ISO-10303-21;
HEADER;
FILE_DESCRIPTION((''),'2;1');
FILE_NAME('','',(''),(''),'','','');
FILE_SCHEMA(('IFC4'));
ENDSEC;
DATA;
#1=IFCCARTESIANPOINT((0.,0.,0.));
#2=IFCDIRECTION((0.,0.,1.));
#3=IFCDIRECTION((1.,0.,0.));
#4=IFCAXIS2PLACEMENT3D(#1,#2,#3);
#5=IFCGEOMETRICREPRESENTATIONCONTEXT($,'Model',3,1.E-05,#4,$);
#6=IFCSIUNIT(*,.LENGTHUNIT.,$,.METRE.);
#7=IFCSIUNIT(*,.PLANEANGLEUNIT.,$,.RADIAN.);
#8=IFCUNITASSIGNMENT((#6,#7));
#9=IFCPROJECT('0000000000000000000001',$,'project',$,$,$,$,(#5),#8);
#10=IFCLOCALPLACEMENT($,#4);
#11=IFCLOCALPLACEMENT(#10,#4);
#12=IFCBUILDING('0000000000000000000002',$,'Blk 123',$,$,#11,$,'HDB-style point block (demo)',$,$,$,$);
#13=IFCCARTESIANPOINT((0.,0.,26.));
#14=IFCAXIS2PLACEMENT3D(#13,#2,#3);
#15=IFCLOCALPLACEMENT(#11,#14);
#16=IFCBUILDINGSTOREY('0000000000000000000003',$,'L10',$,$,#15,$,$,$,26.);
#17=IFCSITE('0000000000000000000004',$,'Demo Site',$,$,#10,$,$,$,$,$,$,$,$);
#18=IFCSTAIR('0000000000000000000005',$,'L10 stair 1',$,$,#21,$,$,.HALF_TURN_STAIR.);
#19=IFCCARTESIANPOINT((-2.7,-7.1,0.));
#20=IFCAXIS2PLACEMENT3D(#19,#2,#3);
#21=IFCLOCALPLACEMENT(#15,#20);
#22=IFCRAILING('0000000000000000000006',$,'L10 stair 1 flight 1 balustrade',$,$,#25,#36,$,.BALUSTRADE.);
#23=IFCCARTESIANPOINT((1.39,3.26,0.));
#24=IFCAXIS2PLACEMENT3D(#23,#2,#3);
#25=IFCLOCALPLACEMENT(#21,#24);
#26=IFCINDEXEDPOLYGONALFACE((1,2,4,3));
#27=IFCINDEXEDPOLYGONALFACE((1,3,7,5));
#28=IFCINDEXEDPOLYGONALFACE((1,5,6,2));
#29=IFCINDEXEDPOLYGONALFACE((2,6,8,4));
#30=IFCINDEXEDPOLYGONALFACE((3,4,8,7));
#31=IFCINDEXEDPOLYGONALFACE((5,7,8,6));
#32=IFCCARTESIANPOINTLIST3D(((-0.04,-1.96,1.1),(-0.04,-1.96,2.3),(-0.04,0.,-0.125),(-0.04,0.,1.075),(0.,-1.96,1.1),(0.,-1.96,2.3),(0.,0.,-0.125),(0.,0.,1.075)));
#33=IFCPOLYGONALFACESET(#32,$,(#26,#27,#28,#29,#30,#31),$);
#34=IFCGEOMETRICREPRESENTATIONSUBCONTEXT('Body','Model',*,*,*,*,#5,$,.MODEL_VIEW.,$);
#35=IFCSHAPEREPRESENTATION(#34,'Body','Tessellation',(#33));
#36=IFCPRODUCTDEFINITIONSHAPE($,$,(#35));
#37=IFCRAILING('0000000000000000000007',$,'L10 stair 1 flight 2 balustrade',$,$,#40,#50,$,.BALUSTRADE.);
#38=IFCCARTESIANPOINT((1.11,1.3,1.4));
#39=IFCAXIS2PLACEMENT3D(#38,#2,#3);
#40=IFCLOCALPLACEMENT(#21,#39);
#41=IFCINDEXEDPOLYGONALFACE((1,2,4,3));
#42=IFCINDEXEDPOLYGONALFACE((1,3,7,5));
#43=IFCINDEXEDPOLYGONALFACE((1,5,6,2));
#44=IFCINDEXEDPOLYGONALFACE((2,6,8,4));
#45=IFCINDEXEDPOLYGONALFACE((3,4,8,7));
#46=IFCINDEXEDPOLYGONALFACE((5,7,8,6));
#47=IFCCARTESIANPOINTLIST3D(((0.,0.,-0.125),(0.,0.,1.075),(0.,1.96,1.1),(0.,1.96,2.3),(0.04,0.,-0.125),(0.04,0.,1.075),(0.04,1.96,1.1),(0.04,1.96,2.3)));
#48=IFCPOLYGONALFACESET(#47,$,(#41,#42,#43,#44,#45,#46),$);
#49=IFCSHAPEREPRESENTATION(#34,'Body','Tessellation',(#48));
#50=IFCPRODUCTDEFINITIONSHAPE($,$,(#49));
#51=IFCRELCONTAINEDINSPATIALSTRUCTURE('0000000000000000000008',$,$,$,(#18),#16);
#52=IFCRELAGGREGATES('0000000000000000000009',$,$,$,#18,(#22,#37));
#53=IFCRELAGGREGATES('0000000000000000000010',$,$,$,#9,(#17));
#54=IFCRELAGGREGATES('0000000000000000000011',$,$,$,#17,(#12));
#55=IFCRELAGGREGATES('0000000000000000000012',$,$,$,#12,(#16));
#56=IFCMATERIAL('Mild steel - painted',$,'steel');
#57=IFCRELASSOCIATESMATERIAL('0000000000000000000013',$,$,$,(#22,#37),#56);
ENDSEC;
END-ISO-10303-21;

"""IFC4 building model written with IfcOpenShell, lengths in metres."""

from ifc_helpers import new_model, si_unit, frame, origin_with_axes, place, context, subcontext, project, spatial, polyline, outline, extrude, material, element, aggregate, save


model = new_model("IFC4")

# Units and contexts
model_context = context("Model", 3, precision=1e-05, world=origin_with_axes())
body_context = subcontext(model_context, "Body", "Model", "MODEL_VIEW")
ifc_project = project(units=[si_unit("LENGTHUNIT", "METRE"), si_unit("PLANEANGLEUNIT", "RADIAN")], contexts=[model_context])

# Site, building, storey
site_placement = place(None, origin_with_axes())
site = spatial("IfcSite", under=ifc_project, at=site_placement, Name="Demo Site")
building_placement = place(site_placement, origin_with_axes())
building = spatial("IfcBuilding", under=site, at=building_placement, Name="Blk 123", LongName="HDB-style point block (demo)")
storey_placement = place(building_placement, frame((0.0, 0.0, 26.0), z_axis=(0.0, 0.0, 1.0), x_axis=(1.0, 0.0, 0.0)))
storey = spatial("IfcBuildingStorey", under=building, at=storey_placement, Name="L10", Elevation=26.0)

# Stair
stair_placement = place(storey_placement, frame((-2.7, -7.1, 0.0), z_axis=(0.0, 0.0, 1.0), x_axis=(1.0, 0.0, 0.0)))
stair = element("IfcStair", 1, at=stair_placement, inside=storey, Name="L10 stair 1", PredefinedType="HALF_TURN_STAIR")

# Railings
ifc_material_1 = material(Name="Mild steel - painted", Category="steel")
railing_1_placement = place(stair_placement, frame((1.39, 3.26, 0.0), z_axis=(0.0, 0.0, 1.0), x_axis=(1.0, 0.0, 0.0)))
railing_1 = element("IfcRailing", 2, at=railing_1_placement, material=ifc_material_1, Name="L10 stair 1 flight 1 balustrade", PredefinedType="BALUSTRADE", context=body_context, shape_type="SweptSolid", body=[
    extrude(outline(polyline([(0.0, -0.125), (1.96, 1.1), (1.96, 2.3), (0.0, 1.075), (0.0, -0.125)])), frame((0.0, 0.0, 0.0), z_axis=(-1.0, 0.0, 0.0), x_axis=(0.0, -1.0, 0.0)), (0.0, 0.0, 1.0), 0.04),
])
railing_2_placement = place(stair_placement, frame((1.11, 1.3, 1.4), z_axis=(0.0, 0.0, 1.0), x_axis=(1.0, 0.0, 0.0)))
railing_2 = element("IfcRailing", 3, at=railing_2_placement, material=ifc_material_1, Name="L10 stair 1 flight 2 balustrade", PredefinedType="BALUSTRADE", context=body_context, shape_type="SweptSolid", body=[
    extrude(outline(polyline([(0.0, -0.125), (1.96, 1.1), (1.96, 2.3), (0.0, 1.075), (0.0, -0.125)])), frame((0.0, 0.0, 0.0), z_axis=(1.0, 0.0, 0.0), x_axis=(0.0, 1.0, 0.0)), (0.0, 0.0, 1.0), 0.04),
])
aggregate(stair, [railing_1, railing_2])

save(model, "model.ifc")
